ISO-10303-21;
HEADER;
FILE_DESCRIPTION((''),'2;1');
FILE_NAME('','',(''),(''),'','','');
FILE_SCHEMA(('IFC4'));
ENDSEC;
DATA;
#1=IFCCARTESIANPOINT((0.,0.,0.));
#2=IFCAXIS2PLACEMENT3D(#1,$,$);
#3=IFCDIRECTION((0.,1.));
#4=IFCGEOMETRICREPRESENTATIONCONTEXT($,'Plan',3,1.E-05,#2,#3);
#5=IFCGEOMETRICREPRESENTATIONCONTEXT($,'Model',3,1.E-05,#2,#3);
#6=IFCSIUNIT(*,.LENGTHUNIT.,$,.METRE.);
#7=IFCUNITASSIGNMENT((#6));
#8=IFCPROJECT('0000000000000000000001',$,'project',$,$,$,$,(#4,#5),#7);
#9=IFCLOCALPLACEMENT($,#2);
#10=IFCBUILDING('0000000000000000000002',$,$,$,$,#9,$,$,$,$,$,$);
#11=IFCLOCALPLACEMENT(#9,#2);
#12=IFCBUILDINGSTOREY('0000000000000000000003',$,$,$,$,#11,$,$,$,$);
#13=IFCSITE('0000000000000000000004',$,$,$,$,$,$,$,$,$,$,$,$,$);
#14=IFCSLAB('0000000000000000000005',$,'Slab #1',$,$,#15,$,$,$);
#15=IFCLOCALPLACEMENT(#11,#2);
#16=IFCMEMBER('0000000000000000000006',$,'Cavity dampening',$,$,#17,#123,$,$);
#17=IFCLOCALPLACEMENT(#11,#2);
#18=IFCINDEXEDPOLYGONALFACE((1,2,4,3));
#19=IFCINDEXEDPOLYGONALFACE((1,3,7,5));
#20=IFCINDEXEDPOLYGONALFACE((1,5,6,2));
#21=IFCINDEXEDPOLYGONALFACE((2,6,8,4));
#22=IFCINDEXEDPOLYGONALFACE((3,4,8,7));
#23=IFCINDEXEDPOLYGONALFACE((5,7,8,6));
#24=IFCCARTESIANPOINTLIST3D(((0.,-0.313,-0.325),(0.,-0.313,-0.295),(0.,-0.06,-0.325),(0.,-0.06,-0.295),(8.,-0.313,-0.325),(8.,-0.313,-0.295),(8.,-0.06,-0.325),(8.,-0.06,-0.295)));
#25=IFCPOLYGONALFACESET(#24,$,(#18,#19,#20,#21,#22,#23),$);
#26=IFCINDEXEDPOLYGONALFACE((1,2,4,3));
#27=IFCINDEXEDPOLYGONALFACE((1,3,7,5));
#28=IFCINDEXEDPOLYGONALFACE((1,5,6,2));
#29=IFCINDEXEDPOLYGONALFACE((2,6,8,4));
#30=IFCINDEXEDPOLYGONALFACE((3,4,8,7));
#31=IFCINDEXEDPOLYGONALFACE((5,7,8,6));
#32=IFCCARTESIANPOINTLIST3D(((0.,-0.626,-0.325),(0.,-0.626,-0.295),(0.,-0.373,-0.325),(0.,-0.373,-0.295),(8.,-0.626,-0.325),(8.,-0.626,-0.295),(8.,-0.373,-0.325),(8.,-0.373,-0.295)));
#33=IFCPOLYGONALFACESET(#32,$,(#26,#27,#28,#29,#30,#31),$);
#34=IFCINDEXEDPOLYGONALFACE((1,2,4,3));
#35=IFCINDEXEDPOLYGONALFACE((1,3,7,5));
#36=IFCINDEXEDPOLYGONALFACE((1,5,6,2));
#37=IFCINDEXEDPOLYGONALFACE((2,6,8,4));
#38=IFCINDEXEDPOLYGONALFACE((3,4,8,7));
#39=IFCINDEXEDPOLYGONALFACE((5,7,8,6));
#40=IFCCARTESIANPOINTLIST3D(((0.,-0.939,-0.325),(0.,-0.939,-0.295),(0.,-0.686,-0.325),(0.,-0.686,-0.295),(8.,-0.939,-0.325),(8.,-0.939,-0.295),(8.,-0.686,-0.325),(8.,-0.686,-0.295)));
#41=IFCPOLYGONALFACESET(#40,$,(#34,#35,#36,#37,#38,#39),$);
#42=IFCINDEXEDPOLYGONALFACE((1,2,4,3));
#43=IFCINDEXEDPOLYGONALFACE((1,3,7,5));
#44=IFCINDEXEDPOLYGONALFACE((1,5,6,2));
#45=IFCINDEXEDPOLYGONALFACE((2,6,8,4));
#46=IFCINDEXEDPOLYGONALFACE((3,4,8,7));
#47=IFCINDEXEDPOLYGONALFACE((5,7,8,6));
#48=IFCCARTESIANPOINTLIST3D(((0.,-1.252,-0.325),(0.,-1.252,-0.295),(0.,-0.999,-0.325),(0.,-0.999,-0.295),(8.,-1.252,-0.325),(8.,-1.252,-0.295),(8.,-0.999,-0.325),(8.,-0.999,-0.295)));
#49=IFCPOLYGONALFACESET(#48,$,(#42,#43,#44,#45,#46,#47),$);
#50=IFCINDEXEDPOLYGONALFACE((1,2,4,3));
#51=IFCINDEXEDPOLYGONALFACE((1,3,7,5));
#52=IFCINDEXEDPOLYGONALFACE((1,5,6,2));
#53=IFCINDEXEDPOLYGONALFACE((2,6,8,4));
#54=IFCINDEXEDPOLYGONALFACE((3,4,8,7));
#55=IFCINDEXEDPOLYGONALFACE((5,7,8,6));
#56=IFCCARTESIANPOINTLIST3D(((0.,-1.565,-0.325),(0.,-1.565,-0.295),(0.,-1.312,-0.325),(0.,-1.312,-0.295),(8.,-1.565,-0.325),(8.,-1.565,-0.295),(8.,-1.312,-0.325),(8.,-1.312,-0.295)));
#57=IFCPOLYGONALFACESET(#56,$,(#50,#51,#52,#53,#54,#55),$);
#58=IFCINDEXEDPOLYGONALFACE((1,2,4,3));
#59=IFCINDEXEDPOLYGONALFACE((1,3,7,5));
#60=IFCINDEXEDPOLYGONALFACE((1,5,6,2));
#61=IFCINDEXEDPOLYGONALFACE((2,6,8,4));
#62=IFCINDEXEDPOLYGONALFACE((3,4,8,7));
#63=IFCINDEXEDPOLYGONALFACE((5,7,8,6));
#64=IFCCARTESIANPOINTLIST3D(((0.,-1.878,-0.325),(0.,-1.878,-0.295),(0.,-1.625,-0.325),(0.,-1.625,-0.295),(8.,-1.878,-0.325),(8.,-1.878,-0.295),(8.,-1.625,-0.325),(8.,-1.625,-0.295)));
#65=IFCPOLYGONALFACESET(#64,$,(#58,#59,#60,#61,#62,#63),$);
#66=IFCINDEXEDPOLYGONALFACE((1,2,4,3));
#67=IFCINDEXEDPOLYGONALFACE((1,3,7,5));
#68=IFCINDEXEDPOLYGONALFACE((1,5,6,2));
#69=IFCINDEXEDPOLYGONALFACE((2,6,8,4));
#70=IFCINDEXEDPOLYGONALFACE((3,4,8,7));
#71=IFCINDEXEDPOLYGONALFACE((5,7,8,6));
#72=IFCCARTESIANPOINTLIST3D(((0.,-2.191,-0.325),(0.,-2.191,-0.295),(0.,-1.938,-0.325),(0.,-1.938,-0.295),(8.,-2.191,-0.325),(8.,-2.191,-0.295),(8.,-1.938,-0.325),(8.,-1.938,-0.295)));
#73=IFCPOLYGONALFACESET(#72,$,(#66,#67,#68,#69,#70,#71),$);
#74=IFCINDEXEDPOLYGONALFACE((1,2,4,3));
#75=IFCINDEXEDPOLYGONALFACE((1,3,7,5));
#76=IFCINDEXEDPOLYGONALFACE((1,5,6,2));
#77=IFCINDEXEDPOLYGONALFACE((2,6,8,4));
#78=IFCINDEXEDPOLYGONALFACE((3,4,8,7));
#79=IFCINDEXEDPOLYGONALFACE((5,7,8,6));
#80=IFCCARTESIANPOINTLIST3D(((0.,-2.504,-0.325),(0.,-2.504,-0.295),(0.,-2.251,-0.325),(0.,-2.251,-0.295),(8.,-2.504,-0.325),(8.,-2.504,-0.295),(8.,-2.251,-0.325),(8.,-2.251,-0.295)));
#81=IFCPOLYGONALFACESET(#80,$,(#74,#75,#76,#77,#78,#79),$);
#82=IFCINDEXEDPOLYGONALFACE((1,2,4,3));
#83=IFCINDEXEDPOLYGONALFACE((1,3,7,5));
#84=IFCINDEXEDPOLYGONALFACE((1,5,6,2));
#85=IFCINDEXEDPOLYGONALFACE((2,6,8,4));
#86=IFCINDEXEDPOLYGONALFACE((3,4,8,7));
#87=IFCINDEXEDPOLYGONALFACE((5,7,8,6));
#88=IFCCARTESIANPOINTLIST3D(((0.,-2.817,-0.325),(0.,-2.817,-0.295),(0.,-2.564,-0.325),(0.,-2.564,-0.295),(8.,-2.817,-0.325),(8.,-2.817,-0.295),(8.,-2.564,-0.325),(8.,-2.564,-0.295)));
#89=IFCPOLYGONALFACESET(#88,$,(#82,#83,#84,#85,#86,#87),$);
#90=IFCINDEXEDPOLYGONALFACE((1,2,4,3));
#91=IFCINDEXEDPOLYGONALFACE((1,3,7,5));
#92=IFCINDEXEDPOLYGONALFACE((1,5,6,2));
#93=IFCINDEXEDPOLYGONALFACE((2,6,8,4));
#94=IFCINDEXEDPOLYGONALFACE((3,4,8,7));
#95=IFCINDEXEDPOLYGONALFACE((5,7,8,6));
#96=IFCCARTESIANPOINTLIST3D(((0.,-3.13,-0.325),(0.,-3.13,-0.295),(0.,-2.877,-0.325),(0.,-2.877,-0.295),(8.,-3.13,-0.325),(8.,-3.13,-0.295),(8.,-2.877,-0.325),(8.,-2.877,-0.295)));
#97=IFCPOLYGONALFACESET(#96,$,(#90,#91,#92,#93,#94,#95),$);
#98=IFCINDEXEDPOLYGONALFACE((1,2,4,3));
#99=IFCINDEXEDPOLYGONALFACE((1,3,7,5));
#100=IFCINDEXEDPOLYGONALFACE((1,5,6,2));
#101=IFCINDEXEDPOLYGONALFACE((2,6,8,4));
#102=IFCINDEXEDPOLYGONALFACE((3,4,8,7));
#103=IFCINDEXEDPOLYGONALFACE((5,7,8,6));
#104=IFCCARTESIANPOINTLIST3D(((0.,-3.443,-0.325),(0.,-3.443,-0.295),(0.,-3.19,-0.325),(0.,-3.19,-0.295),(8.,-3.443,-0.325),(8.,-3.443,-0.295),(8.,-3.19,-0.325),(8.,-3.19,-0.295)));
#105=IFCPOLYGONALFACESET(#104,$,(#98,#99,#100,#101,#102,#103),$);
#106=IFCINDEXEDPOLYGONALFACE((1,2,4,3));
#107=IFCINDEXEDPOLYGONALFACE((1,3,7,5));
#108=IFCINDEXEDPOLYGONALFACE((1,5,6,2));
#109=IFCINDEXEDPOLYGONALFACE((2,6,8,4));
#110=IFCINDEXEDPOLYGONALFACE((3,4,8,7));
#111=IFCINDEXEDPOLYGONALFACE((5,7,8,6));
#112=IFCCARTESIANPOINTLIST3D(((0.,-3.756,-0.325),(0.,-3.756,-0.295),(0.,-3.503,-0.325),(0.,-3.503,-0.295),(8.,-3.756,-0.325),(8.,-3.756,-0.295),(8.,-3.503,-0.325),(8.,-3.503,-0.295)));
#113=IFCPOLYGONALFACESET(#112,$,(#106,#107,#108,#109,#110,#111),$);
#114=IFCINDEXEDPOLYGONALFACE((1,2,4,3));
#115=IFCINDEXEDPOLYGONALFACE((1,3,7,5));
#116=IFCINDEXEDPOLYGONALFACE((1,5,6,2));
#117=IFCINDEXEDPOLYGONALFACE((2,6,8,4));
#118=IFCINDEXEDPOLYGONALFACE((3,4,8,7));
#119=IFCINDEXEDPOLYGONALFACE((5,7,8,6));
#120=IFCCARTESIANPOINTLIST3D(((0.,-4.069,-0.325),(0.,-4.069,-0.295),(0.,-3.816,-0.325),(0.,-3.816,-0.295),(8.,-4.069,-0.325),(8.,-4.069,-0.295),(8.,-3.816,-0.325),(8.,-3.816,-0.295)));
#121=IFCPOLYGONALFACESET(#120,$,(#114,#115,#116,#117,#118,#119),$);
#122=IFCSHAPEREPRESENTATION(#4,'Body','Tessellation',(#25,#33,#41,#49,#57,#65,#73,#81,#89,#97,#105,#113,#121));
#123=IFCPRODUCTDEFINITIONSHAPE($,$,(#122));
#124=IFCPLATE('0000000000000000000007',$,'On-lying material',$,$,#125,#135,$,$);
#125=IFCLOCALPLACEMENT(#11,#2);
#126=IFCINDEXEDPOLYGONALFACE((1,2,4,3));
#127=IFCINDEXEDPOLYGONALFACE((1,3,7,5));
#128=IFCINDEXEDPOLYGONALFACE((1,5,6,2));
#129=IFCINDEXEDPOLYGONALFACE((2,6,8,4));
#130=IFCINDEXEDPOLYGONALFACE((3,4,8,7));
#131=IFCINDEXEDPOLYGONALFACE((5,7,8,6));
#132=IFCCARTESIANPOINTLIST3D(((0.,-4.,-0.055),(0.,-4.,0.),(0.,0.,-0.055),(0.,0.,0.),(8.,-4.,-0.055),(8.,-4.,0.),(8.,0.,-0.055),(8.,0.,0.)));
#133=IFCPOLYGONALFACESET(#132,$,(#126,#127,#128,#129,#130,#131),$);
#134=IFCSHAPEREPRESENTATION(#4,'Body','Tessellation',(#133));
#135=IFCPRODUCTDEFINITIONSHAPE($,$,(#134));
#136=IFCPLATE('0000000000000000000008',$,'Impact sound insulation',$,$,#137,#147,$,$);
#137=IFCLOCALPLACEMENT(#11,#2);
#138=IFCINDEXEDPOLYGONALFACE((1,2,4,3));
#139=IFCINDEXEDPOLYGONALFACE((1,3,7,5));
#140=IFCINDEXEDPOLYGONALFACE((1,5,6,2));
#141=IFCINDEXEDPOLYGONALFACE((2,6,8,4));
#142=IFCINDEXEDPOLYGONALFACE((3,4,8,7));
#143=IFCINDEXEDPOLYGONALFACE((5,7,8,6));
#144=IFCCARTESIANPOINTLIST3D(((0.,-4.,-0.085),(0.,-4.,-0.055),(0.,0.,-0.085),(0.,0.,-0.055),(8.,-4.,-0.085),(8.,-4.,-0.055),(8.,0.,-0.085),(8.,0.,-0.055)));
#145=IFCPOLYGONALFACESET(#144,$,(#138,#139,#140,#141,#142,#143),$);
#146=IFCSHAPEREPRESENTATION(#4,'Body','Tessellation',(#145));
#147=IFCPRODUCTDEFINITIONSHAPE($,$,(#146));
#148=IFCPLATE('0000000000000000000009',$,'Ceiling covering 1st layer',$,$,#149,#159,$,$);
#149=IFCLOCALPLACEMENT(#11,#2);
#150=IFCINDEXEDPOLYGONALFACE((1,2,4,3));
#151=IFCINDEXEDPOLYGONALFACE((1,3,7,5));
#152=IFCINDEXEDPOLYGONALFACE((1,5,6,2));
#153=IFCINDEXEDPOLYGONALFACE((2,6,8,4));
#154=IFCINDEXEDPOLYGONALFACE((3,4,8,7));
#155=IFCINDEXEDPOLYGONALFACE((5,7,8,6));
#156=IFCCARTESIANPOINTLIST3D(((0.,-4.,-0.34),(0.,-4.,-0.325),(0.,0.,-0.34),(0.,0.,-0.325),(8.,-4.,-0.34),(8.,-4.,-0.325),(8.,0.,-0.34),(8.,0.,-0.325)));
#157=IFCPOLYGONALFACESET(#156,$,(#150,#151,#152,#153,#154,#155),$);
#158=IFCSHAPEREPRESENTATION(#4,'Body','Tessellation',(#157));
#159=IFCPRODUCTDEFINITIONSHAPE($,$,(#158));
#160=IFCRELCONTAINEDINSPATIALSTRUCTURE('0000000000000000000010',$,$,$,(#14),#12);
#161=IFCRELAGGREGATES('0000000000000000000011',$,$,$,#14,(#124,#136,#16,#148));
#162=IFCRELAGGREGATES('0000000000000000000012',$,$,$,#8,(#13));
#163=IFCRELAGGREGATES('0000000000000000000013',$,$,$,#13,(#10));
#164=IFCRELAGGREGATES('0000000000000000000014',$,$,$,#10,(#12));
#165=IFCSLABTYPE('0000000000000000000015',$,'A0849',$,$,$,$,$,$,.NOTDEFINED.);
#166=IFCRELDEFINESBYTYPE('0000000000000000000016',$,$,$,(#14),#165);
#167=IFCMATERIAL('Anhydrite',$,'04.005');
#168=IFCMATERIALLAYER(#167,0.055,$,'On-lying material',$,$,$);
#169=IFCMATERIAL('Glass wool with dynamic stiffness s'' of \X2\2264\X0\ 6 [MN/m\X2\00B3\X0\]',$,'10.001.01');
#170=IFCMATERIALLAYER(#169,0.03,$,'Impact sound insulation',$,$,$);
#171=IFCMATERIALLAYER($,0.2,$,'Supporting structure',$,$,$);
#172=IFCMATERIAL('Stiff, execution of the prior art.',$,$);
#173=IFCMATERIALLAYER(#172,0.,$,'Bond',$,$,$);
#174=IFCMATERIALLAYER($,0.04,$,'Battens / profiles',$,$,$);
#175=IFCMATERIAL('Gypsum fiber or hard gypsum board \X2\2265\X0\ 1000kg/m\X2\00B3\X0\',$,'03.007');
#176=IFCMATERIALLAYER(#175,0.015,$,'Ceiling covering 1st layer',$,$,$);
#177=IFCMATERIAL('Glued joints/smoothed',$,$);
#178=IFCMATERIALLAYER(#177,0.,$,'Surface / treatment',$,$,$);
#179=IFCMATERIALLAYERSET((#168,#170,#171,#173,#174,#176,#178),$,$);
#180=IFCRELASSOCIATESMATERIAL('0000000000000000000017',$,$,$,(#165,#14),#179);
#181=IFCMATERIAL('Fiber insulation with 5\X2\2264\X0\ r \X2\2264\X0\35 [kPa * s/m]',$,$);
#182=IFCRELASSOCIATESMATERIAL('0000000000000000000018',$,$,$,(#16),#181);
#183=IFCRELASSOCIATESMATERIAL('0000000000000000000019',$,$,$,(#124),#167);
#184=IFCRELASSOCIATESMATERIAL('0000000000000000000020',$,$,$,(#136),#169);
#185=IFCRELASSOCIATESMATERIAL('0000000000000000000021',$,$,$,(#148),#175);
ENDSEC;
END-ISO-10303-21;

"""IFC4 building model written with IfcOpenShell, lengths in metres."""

from ifc_helpers import new_model, si_unit, direction, frame, frame_2d, origin, origin_with_axes, place, context, project, spatial, rectangle, extrude, material, layer, layer_set, type_object, element, aggregate, save


model = new_model("IFC4")

# Units and contexts
plan_context = context("Plan", 3, precision=1e-05, world=origin(), true_north=direction((0.0, 1.0)))
model_context = context("Model", 3, precision=1e-05, world=origin(), true_north=direction((0.0, 1.0)))
ifc_project = project(units=[si_unit("LENGTHUNIT", "METRE")], contexts=[plan_context, model_context])

# Site, building, storey
site = spatial("IfcSite", under=ifc_project)
building_placement = place(None, origin())
building = spatial("IfcBuilding", under=site, at=building_placement)
storey_placement = place(building_placement, origin())
storey = spatial("IfcBuildingStorey", under=building, at=storey_placement)

# Slab, member, plates
ifc_material_1 = material(Name="Anhydrite", Category="04.005")
ifc_layer_1 = layer(ifc_material_1, 0.055, Name="On-lying material")
ifc_material_2 = material(Name="Glass wool with dynamic stiffness s' of ≤ 6 [MN/m³]", Category="10.001.01")
ifc_layer_2 = layer(ifc_material_2, 0.03, Name="Impact sound insulation")
ifc_layer_3 = layer(None, 0.2, Name="Supporting structure")
ifc_material_3 = material(Name="Stiff, execution of the prior art.")
ifc_layer_4 = layer(ifc_material_3, 0.0, Name="Bond")
ifc_layer_5 = layer(None, 0.04, Name="Battens / profiles")
ifc_material_4 = material(Name="Gypsum fiber or hard gypsum board ≥ 1000kg/m³", Category="03.007")
ifc_layer_6 = layer(ifc_material_4, 0.015, Name="Ceiling covering 1st layer")
ifc_material_5 = material(Name="Glued joints/smoothed")
ifc_layer_7 = layer(ifc_material_5, 0.0, Name="Surface / treatment")
ifc_layer_set = layer_set([ifc_layer_1, ifc_layer_2, ifc_layer_3, ifc_layer_4, ifc_layer_5, ifc_layer_6, ifc_layer_7])
slab_type = type_object("IfcSlabType", Name="A0849", PredefinedType="NOTDEFINED", material=ifc_layer_set)
slab_placement = place(None, frame((0.0, 0.0, 0.0), z_axis=(0.0, 0.0, -1.0), x_axis=(1.0, 0.0, 0.0)))
slab = element("IfcSlab", 1, at=slab_placement, inside=storey, type_object=slab_type, material=ifc_layer_set, Name="Slab #1")
ifc_material_6 = material(Name="Fiber insulation with 5≤ r ≤35 [kPa * s/m]")
member_1_placement = place(slab_placement, origin())
member_1 = element("IfcMember", 2, at=member_1_placement, material=ifc_material_6, Name="Cavity dampening", context=plan_context, shape_type="SweptSolid", body=[
    extrude(rectangle(XDim=0.253, YDim=0.03, at=frame_2d((0.1265, 0.015), x_axis=(1.0, 0.0))), frame((0.0, 0.06, 0.295), z_axis=(1.0, 0.0, 0.0), x_axis=(0.0, 1.0, 0.0)), (0.0, 0.0, 1.0), 8.0),
    extrude(rectangle(XDim=0.253, YDim=0.03, at=frame_2d((0.1265, 0.015), x_axis=(1.0, 0.0))), frame((0.0, 0.373, 0.295), z_axis=(1.0, 0.0, 0.0), x_axis=(0.0, 1.0, 0.0)), (0.0, 0.0, 1.0), 8.0),
    extrude(rectangle(XDim=0.253, YDim=0.03, at=frame_2d((0.1265, 0.015), x_axis=(1.0, 0.0))), frame((0.0, 0.686, 0.295), z_axis=(1.0, 0.0, 0.0), x_axis=(0.0, 1.0, 0.0)), (0.0, 0.0, 1.0), 8.0),
    extrude(rectangle(XDim=0.253, YDim=0.03, at=frame_2d((0.1265, 0.015), x_axis=(1.0, 0.0))), frame((0.0, 0.999, 0.295), z_axis=(1.0, 0.0, 0.0), x_axis=(0.0, 1.0, 0.0)), (0.0, 0.0, 1.0), 8.0),
    extrude(rectangle(XDim=0.253, YDim=0.03, at=frame_2d((0.1265, 0.015), x_axis=(1.0, 0.0))), frame((0.0, 1.312, 0.295), z_axis=(1.0, 0.0, 0.0), x_axis=(0.0, 1.0, 0.0)), (0.0, 0.0, 1.0), 8.0),
    extrude(rectangle(XDim=0.253, YDim=0.03, at=frame_2d((0.1265, 0.015), x_axis=(1.0, 0.0))), frame((0.0, 1.625, 0.295), z_axis=(1.0, 0.0, 0.0), x_axis=(0.0, 1.0, 0.0)), (0.0, 0.0, 1.0), 8.0),
    extrude(rectangle(XDim=0.253, YDim=0.03, at=frame_2d((0.1265, 0.015), x_axis=(1.0, 0.0))), frame((0.0, 1.938, 0.295), z_axis=(1.0, 0.0, 0.0), x_axis=(0.0, 1.0, 0.0)), (0.0, 0.0, 1.0), 8.0),
    extrude(rectangle(XDim=0.253, YDim=0.03, at=frame_2d((0.1265, 0.015), x_axis=(1.0, 0.0))), frame((0.0, 2.251, 0.295), z_axis=(1.0, 0.0, 0.0), x_axis=(0.0, 1.0, 0.0)), (0.0, 0.0, 1.0), 8.0),
    extrude(rectangle(XDim=0.253, YDim=0.03, at=frame_2d((0.1265, 0.015), x_axis=(1.0, 0.0))), frame((0.0, 2.564, 0.295), z_axis=(1.0, 0.0, 0.0), x_axis=(0.0, 1.0, 0.0)), (0.0, 0.0, 1.0), 8.0),
    extrude(rectangle(XDim=0.253, YDim=0.03, at=frame_2d((0.1265, 0.015), x_axis=(1.0, 0.0))), frame((0.0, 2.877, 0.295), z_axis=(1.0, 0.0, 0.0), x_axis=(0.0, 1.0, 0.0)), (0.0, 0.0, 1.0), 8.0),
    extrude(rectangle(XDim=0.253, YDim=0.03, at=frame_2d((0.1265, 0.015), x_axis=(1.0, 0.0))), frame((0.0, 3.19, 0.295), z_axis=(1.0, 0.0, 0.0), x_axis=(0.0, 1.0, 0.0)), (0.0, 0.0, 1.0), 8.0),
    extrude(rectangle(XDim=0.253, YDim=0.03, at=frame_2d((0.1265, 0.015), x_axis=(1.0, 0.0))), frame((0.0, 3.503, 0.295), z_axis=(1.0, 0.0, 0.0), x_axis=(0.0, 1.0, 0.0)), (0.0, 0.0, 1.0), 8.0),
    extrude(rectangle(XDim=0.253, YDim=0.03, at=frame_2d((0.1265, 0.015), x_axis=(1.0, 0.0))), frame((0.0, 3.816, 0.295), z_axis=(1.0, 0.0, 0.0), x_axis=(0.0, 1.0, 0.0)), (0.0, 0.0, 1.0), 8.0),
])
plate_1_placement = place(slab_placement, origin())
plate_1 = element("IfcPlate", 3, at=plate_1_placement, material=ifc_material_1, Name="On-lying material", context=plan_context, shape_type="SweptSolid", body=[
    extrude(rectangle(XDim=8.0, YDim=4.0, at=frame_2d((4.0, 2.0), x_axis=(1.0, 0.0))), origin_with_axes(), (0.0, 0.0, 1.0), 0.055),
])
plate_2_placement = place(slab_placement, origin())
plate_2 = element("IfcPlate", 4, at=plate_2_placement, material=ifc_material_2, Name="Impact sound insulation", context=plan_context, shape_type="SweptSolid", body=[
    extrude(rectangle(XDim=8.0, YDim=4.0, at=frame_2d((4.0, 2.0), x_axis=(1.0, 0.0))), frame((0.0, 0.0, 0.055), z_axis=(0.0, 0.0, 1.0), x_axis=(1.0, 0.0, 0.0)), (0.0, 0.0, 1.0), 0.03),
])
plate_3_placement = place(slab_placement, origin())
plate_3 = element("IfcPlate", 5, at=plate_3_placement, material=ifc_material_4, Name="Ceiling covering 1st layer", context=plan_context, shape_type="SweptSolid", body=[
    extrude(rectangle(XDim=8.0, YDim=4.0, at=frame_2d((4.0, 2.0), x_axis=(1.0, 0.0))), frame((0.0, 0.0, 0.325), z_axis=(0.0, 0.0, 1.0), x_axis=(1.0, 0.0, 0.0)), (0.0, 0.0, 1.0), 0.015),
])
aggregate(slab, [plate_1, plate_2, member_1, plate_3])

save(model, "model.ifc")
